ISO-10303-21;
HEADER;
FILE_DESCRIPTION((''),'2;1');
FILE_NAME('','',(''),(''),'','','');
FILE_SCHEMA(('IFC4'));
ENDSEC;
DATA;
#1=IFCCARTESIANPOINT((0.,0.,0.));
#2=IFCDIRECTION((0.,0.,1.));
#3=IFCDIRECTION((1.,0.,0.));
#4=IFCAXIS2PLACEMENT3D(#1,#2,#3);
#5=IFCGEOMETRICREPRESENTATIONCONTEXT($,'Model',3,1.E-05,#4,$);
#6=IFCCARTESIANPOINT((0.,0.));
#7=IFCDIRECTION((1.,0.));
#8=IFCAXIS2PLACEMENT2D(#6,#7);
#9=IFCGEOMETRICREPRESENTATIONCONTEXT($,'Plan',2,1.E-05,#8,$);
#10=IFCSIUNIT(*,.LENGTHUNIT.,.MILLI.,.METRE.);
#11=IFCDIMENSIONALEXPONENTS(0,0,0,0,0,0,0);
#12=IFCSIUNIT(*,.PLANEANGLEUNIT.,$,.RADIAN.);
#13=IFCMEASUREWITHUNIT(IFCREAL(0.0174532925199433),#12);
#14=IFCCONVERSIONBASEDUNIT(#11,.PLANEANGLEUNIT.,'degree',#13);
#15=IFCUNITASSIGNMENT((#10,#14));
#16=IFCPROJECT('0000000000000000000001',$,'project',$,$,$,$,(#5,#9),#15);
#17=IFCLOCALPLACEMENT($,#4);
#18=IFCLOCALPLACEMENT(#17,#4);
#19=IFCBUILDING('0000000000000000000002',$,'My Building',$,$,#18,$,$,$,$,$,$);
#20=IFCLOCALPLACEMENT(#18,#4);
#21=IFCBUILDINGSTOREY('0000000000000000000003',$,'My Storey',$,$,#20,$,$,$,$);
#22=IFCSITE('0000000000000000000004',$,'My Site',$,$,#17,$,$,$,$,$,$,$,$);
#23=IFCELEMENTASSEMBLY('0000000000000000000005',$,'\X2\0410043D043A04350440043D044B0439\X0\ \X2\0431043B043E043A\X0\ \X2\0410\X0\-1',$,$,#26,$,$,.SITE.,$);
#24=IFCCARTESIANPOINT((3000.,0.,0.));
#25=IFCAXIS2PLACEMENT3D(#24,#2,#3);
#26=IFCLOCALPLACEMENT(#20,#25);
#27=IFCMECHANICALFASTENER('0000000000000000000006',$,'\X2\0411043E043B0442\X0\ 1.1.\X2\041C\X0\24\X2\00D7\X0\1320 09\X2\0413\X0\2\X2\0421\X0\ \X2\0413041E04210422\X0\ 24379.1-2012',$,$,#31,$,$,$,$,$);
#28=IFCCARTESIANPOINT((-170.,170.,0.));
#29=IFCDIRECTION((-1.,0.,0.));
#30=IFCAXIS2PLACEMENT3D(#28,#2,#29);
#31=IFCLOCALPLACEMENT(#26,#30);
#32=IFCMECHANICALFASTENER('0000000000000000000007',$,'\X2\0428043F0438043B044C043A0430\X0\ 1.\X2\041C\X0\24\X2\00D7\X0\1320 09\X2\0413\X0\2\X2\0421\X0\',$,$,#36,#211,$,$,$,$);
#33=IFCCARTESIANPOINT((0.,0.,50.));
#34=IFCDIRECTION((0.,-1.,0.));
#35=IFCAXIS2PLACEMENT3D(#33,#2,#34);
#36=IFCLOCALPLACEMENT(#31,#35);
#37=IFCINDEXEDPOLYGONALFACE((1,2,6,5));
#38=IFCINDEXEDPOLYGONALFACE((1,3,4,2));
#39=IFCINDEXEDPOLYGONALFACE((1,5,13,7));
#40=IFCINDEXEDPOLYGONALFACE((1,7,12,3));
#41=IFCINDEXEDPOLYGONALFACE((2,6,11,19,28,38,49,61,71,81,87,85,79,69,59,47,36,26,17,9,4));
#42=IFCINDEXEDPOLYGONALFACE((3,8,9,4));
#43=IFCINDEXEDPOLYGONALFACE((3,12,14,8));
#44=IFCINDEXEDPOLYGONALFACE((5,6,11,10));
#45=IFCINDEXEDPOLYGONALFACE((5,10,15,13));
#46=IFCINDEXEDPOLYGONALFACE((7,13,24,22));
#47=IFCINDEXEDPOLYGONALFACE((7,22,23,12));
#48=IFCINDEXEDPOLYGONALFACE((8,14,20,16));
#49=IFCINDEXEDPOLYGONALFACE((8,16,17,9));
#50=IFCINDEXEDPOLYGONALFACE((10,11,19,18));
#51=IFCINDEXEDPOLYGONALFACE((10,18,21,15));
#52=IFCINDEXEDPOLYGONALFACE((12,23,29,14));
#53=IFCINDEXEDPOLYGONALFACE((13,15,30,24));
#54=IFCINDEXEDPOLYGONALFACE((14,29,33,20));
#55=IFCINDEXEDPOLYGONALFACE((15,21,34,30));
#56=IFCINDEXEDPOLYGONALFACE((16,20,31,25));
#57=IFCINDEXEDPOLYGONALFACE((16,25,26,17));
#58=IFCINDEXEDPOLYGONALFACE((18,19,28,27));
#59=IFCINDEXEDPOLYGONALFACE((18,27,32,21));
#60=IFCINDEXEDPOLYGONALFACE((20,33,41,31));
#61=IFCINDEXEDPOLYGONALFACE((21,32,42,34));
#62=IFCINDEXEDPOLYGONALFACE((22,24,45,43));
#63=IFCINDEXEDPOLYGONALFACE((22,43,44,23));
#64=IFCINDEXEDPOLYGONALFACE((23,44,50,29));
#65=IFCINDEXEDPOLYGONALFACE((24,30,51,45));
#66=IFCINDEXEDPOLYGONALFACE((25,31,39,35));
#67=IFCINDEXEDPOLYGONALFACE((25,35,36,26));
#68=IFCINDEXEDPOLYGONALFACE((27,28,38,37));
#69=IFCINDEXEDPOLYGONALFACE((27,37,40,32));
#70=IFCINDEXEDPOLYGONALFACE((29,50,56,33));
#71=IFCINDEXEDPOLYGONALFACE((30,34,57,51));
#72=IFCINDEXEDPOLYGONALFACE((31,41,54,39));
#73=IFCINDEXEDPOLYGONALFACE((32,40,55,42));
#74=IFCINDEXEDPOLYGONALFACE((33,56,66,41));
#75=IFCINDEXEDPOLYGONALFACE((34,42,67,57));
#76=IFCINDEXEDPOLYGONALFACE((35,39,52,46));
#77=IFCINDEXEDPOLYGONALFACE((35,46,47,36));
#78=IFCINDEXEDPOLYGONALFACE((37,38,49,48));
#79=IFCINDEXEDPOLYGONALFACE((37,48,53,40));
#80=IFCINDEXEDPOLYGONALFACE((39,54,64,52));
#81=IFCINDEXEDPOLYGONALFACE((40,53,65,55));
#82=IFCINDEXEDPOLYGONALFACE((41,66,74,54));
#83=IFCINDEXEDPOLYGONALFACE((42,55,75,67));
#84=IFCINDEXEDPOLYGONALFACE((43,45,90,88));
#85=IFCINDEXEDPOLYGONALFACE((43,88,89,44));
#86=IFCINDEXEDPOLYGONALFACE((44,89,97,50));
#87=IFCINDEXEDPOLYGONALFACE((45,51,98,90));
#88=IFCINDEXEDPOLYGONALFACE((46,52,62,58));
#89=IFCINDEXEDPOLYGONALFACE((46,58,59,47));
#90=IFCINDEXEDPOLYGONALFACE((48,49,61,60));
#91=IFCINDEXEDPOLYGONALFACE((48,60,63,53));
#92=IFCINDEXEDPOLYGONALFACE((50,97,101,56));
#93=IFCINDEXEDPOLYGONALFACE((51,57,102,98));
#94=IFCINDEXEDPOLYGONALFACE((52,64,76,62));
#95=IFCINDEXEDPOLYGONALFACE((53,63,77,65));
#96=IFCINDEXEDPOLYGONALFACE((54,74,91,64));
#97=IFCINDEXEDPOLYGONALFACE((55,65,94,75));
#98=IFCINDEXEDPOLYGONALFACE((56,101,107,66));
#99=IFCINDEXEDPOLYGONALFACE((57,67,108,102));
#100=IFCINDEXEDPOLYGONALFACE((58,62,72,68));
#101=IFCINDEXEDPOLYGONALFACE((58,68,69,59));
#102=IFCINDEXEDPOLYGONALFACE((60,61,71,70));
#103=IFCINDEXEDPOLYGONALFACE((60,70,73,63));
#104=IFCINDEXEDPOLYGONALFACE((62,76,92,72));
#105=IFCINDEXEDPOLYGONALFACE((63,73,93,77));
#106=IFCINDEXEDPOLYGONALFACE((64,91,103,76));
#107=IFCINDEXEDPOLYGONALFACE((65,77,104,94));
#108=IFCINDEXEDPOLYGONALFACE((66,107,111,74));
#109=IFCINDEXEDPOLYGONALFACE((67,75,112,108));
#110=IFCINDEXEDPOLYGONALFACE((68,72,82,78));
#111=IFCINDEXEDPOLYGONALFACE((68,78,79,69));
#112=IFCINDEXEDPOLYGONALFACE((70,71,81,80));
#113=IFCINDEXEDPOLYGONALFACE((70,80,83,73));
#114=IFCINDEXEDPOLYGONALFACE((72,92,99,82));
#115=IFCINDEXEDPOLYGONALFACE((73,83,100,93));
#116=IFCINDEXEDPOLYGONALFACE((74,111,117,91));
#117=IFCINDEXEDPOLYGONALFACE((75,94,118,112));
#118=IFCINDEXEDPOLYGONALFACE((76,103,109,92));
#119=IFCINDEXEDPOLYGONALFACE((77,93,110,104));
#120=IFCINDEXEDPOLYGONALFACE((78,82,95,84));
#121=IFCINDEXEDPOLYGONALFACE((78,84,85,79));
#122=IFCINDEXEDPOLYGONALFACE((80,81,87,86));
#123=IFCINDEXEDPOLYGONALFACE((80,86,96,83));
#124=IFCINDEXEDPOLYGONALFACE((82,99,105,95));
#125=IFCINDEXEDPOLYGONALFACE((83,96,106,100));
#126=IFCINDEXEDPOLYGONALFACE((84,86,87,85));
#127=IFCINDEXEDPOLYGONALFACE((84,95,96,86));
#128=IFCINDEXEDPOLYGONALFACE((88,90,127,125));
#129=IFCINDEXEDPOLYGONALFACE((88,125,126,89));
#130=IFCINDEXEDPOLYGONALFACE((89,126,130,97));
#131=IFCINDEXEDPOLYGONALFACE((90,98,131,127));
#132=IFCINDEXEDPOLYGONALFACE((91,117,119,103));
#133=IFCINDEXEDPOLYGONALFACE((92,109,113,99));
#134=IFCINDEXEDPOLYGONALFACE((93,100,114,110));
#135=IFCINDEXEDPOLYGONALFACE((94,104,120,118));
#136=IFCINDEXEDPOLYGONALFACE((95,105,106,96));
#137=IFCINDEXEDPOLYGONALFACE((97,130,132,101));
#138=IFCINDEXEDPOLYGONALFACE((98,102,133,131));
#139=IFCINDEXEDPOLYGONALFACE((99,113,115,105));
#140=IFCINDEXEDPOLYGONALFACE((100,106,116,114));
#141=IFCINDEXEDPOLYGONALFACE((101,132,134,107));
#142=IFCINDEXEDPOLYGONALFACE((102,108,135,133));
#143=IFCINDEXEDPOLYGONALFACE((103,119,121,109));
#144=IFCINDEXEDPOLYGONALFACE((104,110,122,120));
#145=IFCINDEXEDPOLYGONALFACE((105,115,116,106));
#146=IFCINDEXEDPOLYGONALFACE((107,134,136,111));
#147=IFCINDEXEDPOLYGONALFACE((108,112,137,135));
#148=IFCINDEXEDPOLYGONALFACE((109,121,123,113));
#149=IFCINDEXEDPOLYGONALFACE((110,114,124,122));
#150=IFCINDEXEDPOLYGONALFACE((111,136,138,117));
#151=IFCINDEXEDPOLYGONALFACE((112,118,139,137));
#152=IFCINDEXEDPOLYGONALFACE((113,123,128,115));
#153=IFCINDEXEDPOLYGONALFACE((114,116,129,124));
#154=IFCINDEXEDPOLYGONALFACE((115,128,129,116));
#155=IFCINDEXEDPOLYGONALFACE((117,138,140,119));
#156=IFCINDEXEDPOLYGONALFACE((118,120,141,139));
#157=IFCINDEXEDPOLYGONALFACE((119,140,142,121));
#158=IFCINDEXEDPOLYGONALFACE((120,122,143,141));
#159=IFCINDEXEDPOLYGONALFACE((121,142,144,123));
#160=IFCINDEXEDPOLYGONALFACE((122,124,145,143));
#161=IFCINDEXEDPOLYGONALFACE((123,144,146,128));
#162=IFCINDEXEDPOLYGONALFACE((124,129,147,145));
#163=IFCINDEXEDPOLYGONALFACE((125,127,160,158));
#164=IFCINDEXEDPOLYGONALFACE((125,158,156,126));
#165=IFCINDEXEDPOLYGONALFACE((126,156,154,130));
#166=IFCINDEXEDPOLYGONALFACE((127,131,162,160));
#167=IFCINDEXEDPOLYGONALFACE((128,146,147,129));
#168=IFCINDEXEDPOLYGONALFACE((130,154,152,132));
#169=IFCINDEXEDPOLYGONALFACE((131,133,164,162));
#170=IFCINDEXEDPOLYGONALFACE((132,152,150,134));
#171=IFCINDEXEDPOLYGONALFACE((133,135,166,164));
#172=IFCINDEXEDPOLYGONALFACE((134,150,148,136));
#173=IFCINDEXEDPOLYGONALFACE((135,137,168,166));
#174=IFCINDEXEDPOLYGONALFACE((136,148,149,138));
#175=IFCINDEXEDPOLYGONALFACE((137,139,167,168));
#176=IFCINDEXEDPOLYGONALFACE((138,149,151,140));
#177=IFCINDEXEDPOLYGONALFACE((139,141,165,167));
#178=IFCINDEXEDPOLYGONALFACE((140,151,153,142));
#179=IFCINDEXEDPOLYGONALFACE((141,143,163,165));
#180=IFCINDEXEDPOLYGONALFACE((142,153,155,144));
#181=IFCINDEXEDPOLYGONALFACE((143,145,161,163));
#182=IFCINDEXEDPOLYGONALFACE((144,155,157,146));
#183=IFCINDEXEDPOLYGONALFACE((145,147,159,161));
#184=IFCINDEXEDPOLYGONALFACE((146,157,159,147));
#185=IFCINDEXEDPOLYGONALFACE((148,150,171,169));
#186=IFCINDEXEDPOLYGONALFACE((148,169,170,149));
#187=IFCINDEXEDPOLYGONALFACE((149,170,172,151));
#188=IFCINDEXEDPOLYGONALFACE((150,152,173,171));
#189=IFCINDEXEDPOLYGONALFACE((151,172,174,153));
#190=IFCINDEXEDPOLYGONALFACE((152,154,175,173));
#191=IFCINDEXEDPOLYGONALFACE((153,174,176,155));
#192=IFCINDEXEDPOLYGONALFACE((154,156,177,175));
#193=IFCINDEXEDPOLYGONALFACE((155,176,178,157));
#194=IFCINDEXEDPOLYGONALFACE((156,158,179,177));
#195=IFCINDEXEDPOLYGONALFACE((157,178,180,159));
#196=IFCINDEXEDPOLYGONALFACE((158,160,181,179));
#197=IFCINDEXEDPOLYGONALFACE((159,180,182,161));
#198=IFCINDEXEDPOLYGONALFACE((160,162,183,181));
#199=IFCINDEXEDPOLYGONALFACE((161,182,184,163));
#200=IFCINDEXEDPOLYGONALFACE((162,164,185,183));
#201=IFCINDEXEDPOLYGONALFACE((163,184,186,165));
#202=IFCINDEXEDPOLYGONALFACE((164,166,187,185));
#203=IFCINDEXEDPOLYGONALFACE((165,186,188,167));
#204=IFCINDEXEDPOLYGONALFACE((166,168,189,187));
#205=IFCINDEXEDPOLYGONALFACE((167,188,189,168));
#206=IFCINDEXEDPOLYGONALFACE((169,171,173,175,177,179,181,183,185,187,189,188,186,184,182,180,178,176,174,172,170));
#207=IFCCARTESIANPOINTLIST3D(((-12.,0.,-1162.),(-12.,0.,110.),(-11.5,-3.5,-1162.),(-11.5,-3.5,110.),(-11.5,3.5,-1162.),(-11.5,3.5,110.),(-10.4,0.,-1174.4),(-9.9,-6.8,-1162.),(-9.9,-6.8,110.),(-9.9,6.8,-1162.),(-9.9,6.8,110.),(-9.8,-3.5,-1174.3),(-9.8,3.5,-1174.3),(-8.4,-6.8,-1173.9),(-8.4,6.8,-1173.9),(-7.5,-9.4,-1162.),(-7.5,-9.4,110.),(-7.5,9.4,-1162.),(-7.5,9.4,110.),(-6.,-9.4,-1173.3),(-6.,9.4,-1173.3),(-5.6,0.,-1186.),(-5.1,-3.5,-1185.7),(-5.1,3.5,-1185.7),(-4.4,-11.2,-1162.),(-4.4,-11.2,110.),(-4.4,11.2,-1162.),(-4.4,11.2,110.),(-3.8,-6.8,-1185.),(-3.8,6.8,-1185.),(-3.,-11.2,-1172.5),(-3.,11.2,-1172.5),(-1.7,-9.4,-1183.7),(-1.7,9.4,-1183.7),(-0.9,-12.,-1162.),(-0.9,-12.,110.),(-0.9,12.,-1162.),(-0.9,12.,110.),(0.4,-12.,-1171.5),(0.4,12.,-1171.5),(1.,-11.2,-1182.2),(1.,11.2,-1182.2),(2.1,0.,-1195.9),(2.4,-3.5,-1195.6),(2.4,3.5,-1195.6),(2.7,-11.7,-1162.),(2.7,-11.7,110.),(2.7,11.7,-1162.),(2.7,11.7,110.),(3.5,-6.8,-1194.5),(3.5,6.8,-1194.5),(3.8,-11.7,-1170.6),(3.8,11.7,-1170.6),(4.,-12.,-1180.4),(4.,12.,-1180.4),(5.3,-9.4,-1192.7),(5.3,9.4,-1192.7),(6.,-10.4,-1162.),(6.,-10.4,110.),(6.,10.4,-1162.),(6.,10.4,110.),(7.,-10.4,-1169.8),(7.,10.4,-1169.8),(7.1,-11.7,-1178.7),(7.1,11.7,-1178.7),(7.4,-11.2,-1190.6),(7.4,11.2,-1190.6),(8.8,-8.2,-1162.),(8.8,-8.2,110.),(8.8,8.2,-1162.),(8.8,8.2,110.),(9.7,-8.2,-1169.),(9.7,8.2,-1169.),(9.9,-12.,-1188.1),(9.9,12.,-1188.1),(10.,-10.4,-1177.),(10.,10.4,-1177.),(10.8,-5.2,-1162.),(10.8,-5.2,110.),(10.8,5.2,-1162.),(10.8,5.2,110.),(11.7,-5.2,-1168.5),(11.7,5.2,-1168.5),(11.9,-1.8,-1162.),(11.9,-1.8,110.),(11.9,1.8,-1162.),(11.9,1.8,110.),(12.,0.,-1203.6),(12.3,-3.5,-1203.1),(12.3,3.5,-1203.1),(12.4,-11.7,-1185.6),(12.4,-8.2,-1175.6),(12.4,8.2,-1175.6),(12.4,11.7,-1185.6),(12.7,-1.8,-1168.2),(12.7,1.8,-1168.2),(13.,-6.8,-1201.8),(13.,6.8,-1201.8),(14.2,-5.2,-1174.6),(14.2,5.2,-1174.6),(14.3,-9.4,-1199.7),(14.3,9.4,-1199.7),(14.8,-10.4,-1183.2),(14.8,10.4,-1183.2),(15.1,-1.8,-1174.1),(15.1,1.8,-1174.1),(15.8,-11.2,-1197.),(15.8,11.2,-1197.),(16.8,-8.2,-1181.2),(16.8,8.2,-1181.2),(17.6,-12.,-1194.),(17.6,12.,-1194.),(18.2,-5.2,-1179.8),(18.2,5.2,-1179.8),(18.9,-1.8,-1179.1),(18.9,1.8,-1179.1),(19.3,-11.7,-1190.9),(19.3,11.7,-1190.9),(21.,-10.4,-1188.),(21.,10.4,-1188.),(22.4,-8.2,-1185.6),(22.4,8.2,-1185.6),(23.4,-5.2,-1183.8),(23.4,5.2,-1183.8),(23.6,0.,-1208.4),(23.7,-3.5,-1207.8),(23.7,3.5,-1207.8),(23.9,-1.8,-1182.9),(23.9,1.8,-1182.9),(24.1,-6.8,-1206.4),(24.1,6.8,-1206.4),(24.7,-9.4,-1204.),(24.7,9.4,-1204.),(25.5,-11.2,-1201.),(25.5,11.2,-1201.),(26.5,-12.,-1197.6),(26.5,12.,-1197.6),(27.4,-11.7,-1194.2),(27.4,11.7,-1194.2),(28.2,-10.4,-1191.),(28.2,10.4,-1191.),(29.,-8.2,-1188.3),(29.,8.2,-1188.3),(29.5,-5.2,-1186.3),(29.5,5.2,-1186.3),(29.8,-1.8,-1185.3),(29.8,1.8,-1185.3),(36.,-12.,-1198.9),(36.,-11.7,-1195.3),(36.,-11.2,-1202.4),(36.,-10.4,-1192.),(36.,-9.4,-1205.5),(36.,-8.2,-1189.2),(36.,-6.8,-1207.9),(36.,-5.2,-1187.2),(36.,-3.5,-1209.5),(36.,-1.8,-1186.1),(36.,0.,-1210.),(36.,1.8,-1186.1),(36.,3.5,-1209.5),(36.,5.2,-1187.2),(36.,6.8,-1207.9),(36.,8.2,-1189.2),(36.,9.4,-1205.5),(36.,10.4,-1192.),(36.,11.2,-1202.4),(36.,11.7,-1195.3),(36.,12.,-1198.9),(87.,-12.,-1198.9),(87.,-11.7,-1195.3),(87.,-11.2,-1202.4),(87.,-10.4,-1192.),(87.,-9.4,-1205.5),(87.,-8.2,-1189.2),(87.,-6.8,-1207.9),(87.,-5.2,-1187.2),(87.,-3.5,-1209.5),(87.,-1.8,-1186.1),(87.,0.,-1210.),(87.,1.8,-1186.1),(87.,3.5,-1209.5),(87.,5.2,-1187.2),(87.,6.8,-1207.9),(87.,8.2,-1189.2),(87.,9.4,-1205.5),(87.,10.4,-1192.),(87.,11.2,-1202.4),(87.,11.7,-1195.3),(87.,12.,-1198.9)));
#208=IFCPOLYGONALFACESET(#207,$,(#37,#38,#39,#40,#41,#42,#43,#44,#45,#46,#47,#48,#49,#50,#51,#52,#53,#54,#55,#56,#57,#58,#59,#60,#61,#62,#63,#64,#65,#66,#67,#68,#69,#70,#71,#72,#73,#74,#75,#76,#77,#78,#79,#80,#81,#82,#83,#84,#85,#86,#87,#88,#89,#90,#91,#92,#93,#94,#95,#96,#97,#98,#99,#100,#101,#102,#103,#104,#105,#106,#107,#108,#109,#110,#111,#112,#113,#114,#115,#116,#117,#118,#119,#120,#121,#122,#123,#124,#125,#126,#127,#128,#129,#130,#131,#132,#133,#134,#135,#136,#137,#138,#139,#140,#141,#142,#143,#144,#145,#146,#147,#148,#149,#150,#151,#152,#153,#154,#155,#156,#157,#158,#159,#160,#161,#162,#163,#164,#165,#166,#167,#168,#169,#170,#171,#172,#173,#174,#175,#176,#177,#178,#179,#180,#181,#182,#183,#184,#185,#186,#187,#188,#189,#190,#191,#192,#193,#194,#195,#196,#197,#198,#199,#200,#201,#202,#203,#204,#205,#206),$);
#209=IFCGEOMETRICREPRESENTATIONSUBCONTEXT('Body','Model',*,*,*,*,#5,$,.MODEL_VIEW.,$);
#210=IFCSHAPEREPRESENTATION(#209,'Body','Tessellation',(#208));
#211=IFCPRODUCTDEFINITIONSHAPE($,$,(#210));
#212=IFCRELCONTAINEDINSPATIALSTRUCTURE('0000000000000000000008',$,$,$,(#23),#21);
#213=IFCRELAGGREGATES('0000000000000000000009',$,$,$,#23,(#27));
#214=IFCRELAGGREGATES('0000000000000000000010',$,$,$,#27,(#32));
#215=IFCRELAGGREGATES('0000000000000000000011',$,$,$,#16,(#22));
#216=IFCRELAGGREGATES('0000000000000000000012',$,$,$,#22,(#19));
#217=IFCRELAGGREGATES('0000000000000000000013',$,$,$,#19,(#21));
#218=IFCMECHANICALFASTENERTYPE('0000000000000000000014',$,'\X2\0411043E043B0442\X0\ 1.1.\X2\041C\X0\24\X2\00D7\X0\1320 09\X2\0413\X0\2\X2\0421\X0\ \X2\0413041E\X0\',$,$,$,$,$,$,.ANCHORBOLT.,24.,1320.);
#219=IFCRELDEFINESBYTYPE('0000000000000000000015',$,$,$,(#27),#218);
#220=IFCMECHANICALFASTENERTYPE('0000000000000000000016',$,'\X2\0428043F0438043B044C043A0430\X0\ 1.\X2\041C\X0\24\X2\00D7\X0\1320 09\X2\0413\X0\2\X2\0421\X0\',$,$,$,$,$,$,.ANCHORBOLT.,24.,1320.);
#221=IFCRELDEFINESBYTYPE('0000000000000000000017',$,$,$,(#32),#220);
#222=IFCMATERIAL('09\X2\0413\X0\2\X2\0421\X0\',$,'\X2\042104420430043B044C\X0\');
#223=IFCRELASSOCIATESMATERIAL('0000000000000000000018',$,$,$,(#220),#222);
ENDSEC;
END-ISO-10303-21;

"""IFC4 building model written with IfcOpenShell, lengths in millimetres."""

from ifc_helpers import new_model, entity, si_unit, converted_unit, frame, origin_with_axes, origin_2d_with_axis, place, context, subcontext, project, spatial, source, transform, mapped, material, type_object, type_shapes, element, aggregate, save


model = new_model("IFC4")

# Units and contexts
model_context = context("Model", 3, precision=1e-05, world=origin_with_axes())
plan_context = context("Plan", 2, precision=1e-05, world=origin_2d_with_axis())
body_context = subcontext(model_context, "Body", "Model", "MODEL_VIEW")
ifc_project = project(units=[si_unit("LENGTHUNIT", "METRE", prefix="MILLI"), converted_unit("PLANEANGLEUNIT", "degree", entity("IfcReal", 0.0174532925199433), si_unit("PLANEANGLEUNIT", "RADIAN"), dimensions=[0, 0, 0, 0, 0, 0, 0])], contexts=[model_context, plan_context])

# Site, building, storey
site_placement = place(None, origin_with_axes())
site = spatial("IfcSite", under=ifc_project, at=site_placement, Name="My Site")
building_placement = place(site_placement, origin_with_axes())
building = spatial("IfcBuilding", under=site, at=building_placement, Name="My Building")
storey_placement = place(building_placement, origin_with_axes())
storey = spatial("IfcBuildingStorey", under=building, at=storey_placement, Name="My Storey")

# Shared definitions
placement = place(storey_placement, frame((3000.0, 0.0, 0.0), z_axis=(0.0, 0.0, 1.0), x_axis=(1.0, 0.0, 0.0)))

# Element assembly, mechanical fasteners
assembly = element("IfcElementAssembly", 1, at=placement, inside=storey, Name="Анкерный блок А-1", AssemblyPlace="SITE")
mechanical_fastener_type_1 = type_object("IfcMechanicalFastenerType", Name="Болт 1.1.М24×1320 09Г2С ГО", NominalDiameter=24.0, NominalLength=1320.0, PredefinedType="ANCHORBOLT")
mechanical_fastener_1_placement = place(placement, frame((-170.0, 170.0, 0.0), z_axis=(0.0, 0.0, 1.0), x_axis=(-1.0, 0.0, 0.0)))
mechanical_fastener_1 = element("IfcMechanicalFastener", 2, at=mechanical_fastener_1_placement, type_object=mechanical_fastener_type_1, Name="Болт 1.1.М24×1320 09Г2С ГОСТ 24379.1-2012")
ifc_material_1 = material(Name="09Г2С", Category="Сталь")
mechanical_fastener_type_2 = type_object("IfcMechanicalFastenerType", Name="Шпилька 1.М24×1320 09Г2С", NominalDiameter=24.0, NominalLength=1320.0, PredefinedType="ANCHORBOLT", material=ifc_material_1)
shared_shape_1 = source(frame((0.0, 0.0, 110.0), z_axis=(0.0, 0.0, 1.0), x_axis=(1.0, 0.0, 0.0)), body_context, "Body", "AdvancedSweptSolid", [
    entity("IfcSweptDiskSolid", entity("IfcIndexedPolyCurve", entity("IfcCartesianPointList3D", [[0.0, 0.0, 0.0], [0.0, 0.0, -1272.0], [10.5, 0.0, -1297.5], [36.0, 0.0, -1308.0], [87.0, 0.0, -1308.0]]), [entity("IfcLineIndex", [1, 2]), entity("IfcArcIndex", [2, 3, 4]), entity("IfcLineIndex", [4, 5])]), 12.0),
])
type_shapes(mechanical_fastener_type_2, [shared_shape_1])
mechanical_fastener_2_placement = place(mechanical_fastener_1_placement, frame((0.0, 0.0, 50.0), z_axis=(0.0, 0.0, 1.0), x_axis=(0.0, -1.0, 0.0)))
mechanical_fastener_2 = element("IfcMechanicalFastener", 3, at=mechanical_fastener_2_placement, type_object=mechanical_fastener_type_2, Name="Шпилька 1.М24×1320 09Г2С", context=body_context, shape_type="MappedRepresentation", body=[
    mapped(shared_shape_1, transform((0.0, 0.0, 0.0), x_axis=(1.0, 0.0, 0.0), y_axis=(0.0, 1.0, 0.0), z_axis=(0.0, 0.0, 1.0), scale=1.0)),
])
aggregate(assembly, [mechanical_fastener_1])
aggregate(mechanical_fastener_1, [mechanical_fastener_2])

save(model, "model.ifc")
